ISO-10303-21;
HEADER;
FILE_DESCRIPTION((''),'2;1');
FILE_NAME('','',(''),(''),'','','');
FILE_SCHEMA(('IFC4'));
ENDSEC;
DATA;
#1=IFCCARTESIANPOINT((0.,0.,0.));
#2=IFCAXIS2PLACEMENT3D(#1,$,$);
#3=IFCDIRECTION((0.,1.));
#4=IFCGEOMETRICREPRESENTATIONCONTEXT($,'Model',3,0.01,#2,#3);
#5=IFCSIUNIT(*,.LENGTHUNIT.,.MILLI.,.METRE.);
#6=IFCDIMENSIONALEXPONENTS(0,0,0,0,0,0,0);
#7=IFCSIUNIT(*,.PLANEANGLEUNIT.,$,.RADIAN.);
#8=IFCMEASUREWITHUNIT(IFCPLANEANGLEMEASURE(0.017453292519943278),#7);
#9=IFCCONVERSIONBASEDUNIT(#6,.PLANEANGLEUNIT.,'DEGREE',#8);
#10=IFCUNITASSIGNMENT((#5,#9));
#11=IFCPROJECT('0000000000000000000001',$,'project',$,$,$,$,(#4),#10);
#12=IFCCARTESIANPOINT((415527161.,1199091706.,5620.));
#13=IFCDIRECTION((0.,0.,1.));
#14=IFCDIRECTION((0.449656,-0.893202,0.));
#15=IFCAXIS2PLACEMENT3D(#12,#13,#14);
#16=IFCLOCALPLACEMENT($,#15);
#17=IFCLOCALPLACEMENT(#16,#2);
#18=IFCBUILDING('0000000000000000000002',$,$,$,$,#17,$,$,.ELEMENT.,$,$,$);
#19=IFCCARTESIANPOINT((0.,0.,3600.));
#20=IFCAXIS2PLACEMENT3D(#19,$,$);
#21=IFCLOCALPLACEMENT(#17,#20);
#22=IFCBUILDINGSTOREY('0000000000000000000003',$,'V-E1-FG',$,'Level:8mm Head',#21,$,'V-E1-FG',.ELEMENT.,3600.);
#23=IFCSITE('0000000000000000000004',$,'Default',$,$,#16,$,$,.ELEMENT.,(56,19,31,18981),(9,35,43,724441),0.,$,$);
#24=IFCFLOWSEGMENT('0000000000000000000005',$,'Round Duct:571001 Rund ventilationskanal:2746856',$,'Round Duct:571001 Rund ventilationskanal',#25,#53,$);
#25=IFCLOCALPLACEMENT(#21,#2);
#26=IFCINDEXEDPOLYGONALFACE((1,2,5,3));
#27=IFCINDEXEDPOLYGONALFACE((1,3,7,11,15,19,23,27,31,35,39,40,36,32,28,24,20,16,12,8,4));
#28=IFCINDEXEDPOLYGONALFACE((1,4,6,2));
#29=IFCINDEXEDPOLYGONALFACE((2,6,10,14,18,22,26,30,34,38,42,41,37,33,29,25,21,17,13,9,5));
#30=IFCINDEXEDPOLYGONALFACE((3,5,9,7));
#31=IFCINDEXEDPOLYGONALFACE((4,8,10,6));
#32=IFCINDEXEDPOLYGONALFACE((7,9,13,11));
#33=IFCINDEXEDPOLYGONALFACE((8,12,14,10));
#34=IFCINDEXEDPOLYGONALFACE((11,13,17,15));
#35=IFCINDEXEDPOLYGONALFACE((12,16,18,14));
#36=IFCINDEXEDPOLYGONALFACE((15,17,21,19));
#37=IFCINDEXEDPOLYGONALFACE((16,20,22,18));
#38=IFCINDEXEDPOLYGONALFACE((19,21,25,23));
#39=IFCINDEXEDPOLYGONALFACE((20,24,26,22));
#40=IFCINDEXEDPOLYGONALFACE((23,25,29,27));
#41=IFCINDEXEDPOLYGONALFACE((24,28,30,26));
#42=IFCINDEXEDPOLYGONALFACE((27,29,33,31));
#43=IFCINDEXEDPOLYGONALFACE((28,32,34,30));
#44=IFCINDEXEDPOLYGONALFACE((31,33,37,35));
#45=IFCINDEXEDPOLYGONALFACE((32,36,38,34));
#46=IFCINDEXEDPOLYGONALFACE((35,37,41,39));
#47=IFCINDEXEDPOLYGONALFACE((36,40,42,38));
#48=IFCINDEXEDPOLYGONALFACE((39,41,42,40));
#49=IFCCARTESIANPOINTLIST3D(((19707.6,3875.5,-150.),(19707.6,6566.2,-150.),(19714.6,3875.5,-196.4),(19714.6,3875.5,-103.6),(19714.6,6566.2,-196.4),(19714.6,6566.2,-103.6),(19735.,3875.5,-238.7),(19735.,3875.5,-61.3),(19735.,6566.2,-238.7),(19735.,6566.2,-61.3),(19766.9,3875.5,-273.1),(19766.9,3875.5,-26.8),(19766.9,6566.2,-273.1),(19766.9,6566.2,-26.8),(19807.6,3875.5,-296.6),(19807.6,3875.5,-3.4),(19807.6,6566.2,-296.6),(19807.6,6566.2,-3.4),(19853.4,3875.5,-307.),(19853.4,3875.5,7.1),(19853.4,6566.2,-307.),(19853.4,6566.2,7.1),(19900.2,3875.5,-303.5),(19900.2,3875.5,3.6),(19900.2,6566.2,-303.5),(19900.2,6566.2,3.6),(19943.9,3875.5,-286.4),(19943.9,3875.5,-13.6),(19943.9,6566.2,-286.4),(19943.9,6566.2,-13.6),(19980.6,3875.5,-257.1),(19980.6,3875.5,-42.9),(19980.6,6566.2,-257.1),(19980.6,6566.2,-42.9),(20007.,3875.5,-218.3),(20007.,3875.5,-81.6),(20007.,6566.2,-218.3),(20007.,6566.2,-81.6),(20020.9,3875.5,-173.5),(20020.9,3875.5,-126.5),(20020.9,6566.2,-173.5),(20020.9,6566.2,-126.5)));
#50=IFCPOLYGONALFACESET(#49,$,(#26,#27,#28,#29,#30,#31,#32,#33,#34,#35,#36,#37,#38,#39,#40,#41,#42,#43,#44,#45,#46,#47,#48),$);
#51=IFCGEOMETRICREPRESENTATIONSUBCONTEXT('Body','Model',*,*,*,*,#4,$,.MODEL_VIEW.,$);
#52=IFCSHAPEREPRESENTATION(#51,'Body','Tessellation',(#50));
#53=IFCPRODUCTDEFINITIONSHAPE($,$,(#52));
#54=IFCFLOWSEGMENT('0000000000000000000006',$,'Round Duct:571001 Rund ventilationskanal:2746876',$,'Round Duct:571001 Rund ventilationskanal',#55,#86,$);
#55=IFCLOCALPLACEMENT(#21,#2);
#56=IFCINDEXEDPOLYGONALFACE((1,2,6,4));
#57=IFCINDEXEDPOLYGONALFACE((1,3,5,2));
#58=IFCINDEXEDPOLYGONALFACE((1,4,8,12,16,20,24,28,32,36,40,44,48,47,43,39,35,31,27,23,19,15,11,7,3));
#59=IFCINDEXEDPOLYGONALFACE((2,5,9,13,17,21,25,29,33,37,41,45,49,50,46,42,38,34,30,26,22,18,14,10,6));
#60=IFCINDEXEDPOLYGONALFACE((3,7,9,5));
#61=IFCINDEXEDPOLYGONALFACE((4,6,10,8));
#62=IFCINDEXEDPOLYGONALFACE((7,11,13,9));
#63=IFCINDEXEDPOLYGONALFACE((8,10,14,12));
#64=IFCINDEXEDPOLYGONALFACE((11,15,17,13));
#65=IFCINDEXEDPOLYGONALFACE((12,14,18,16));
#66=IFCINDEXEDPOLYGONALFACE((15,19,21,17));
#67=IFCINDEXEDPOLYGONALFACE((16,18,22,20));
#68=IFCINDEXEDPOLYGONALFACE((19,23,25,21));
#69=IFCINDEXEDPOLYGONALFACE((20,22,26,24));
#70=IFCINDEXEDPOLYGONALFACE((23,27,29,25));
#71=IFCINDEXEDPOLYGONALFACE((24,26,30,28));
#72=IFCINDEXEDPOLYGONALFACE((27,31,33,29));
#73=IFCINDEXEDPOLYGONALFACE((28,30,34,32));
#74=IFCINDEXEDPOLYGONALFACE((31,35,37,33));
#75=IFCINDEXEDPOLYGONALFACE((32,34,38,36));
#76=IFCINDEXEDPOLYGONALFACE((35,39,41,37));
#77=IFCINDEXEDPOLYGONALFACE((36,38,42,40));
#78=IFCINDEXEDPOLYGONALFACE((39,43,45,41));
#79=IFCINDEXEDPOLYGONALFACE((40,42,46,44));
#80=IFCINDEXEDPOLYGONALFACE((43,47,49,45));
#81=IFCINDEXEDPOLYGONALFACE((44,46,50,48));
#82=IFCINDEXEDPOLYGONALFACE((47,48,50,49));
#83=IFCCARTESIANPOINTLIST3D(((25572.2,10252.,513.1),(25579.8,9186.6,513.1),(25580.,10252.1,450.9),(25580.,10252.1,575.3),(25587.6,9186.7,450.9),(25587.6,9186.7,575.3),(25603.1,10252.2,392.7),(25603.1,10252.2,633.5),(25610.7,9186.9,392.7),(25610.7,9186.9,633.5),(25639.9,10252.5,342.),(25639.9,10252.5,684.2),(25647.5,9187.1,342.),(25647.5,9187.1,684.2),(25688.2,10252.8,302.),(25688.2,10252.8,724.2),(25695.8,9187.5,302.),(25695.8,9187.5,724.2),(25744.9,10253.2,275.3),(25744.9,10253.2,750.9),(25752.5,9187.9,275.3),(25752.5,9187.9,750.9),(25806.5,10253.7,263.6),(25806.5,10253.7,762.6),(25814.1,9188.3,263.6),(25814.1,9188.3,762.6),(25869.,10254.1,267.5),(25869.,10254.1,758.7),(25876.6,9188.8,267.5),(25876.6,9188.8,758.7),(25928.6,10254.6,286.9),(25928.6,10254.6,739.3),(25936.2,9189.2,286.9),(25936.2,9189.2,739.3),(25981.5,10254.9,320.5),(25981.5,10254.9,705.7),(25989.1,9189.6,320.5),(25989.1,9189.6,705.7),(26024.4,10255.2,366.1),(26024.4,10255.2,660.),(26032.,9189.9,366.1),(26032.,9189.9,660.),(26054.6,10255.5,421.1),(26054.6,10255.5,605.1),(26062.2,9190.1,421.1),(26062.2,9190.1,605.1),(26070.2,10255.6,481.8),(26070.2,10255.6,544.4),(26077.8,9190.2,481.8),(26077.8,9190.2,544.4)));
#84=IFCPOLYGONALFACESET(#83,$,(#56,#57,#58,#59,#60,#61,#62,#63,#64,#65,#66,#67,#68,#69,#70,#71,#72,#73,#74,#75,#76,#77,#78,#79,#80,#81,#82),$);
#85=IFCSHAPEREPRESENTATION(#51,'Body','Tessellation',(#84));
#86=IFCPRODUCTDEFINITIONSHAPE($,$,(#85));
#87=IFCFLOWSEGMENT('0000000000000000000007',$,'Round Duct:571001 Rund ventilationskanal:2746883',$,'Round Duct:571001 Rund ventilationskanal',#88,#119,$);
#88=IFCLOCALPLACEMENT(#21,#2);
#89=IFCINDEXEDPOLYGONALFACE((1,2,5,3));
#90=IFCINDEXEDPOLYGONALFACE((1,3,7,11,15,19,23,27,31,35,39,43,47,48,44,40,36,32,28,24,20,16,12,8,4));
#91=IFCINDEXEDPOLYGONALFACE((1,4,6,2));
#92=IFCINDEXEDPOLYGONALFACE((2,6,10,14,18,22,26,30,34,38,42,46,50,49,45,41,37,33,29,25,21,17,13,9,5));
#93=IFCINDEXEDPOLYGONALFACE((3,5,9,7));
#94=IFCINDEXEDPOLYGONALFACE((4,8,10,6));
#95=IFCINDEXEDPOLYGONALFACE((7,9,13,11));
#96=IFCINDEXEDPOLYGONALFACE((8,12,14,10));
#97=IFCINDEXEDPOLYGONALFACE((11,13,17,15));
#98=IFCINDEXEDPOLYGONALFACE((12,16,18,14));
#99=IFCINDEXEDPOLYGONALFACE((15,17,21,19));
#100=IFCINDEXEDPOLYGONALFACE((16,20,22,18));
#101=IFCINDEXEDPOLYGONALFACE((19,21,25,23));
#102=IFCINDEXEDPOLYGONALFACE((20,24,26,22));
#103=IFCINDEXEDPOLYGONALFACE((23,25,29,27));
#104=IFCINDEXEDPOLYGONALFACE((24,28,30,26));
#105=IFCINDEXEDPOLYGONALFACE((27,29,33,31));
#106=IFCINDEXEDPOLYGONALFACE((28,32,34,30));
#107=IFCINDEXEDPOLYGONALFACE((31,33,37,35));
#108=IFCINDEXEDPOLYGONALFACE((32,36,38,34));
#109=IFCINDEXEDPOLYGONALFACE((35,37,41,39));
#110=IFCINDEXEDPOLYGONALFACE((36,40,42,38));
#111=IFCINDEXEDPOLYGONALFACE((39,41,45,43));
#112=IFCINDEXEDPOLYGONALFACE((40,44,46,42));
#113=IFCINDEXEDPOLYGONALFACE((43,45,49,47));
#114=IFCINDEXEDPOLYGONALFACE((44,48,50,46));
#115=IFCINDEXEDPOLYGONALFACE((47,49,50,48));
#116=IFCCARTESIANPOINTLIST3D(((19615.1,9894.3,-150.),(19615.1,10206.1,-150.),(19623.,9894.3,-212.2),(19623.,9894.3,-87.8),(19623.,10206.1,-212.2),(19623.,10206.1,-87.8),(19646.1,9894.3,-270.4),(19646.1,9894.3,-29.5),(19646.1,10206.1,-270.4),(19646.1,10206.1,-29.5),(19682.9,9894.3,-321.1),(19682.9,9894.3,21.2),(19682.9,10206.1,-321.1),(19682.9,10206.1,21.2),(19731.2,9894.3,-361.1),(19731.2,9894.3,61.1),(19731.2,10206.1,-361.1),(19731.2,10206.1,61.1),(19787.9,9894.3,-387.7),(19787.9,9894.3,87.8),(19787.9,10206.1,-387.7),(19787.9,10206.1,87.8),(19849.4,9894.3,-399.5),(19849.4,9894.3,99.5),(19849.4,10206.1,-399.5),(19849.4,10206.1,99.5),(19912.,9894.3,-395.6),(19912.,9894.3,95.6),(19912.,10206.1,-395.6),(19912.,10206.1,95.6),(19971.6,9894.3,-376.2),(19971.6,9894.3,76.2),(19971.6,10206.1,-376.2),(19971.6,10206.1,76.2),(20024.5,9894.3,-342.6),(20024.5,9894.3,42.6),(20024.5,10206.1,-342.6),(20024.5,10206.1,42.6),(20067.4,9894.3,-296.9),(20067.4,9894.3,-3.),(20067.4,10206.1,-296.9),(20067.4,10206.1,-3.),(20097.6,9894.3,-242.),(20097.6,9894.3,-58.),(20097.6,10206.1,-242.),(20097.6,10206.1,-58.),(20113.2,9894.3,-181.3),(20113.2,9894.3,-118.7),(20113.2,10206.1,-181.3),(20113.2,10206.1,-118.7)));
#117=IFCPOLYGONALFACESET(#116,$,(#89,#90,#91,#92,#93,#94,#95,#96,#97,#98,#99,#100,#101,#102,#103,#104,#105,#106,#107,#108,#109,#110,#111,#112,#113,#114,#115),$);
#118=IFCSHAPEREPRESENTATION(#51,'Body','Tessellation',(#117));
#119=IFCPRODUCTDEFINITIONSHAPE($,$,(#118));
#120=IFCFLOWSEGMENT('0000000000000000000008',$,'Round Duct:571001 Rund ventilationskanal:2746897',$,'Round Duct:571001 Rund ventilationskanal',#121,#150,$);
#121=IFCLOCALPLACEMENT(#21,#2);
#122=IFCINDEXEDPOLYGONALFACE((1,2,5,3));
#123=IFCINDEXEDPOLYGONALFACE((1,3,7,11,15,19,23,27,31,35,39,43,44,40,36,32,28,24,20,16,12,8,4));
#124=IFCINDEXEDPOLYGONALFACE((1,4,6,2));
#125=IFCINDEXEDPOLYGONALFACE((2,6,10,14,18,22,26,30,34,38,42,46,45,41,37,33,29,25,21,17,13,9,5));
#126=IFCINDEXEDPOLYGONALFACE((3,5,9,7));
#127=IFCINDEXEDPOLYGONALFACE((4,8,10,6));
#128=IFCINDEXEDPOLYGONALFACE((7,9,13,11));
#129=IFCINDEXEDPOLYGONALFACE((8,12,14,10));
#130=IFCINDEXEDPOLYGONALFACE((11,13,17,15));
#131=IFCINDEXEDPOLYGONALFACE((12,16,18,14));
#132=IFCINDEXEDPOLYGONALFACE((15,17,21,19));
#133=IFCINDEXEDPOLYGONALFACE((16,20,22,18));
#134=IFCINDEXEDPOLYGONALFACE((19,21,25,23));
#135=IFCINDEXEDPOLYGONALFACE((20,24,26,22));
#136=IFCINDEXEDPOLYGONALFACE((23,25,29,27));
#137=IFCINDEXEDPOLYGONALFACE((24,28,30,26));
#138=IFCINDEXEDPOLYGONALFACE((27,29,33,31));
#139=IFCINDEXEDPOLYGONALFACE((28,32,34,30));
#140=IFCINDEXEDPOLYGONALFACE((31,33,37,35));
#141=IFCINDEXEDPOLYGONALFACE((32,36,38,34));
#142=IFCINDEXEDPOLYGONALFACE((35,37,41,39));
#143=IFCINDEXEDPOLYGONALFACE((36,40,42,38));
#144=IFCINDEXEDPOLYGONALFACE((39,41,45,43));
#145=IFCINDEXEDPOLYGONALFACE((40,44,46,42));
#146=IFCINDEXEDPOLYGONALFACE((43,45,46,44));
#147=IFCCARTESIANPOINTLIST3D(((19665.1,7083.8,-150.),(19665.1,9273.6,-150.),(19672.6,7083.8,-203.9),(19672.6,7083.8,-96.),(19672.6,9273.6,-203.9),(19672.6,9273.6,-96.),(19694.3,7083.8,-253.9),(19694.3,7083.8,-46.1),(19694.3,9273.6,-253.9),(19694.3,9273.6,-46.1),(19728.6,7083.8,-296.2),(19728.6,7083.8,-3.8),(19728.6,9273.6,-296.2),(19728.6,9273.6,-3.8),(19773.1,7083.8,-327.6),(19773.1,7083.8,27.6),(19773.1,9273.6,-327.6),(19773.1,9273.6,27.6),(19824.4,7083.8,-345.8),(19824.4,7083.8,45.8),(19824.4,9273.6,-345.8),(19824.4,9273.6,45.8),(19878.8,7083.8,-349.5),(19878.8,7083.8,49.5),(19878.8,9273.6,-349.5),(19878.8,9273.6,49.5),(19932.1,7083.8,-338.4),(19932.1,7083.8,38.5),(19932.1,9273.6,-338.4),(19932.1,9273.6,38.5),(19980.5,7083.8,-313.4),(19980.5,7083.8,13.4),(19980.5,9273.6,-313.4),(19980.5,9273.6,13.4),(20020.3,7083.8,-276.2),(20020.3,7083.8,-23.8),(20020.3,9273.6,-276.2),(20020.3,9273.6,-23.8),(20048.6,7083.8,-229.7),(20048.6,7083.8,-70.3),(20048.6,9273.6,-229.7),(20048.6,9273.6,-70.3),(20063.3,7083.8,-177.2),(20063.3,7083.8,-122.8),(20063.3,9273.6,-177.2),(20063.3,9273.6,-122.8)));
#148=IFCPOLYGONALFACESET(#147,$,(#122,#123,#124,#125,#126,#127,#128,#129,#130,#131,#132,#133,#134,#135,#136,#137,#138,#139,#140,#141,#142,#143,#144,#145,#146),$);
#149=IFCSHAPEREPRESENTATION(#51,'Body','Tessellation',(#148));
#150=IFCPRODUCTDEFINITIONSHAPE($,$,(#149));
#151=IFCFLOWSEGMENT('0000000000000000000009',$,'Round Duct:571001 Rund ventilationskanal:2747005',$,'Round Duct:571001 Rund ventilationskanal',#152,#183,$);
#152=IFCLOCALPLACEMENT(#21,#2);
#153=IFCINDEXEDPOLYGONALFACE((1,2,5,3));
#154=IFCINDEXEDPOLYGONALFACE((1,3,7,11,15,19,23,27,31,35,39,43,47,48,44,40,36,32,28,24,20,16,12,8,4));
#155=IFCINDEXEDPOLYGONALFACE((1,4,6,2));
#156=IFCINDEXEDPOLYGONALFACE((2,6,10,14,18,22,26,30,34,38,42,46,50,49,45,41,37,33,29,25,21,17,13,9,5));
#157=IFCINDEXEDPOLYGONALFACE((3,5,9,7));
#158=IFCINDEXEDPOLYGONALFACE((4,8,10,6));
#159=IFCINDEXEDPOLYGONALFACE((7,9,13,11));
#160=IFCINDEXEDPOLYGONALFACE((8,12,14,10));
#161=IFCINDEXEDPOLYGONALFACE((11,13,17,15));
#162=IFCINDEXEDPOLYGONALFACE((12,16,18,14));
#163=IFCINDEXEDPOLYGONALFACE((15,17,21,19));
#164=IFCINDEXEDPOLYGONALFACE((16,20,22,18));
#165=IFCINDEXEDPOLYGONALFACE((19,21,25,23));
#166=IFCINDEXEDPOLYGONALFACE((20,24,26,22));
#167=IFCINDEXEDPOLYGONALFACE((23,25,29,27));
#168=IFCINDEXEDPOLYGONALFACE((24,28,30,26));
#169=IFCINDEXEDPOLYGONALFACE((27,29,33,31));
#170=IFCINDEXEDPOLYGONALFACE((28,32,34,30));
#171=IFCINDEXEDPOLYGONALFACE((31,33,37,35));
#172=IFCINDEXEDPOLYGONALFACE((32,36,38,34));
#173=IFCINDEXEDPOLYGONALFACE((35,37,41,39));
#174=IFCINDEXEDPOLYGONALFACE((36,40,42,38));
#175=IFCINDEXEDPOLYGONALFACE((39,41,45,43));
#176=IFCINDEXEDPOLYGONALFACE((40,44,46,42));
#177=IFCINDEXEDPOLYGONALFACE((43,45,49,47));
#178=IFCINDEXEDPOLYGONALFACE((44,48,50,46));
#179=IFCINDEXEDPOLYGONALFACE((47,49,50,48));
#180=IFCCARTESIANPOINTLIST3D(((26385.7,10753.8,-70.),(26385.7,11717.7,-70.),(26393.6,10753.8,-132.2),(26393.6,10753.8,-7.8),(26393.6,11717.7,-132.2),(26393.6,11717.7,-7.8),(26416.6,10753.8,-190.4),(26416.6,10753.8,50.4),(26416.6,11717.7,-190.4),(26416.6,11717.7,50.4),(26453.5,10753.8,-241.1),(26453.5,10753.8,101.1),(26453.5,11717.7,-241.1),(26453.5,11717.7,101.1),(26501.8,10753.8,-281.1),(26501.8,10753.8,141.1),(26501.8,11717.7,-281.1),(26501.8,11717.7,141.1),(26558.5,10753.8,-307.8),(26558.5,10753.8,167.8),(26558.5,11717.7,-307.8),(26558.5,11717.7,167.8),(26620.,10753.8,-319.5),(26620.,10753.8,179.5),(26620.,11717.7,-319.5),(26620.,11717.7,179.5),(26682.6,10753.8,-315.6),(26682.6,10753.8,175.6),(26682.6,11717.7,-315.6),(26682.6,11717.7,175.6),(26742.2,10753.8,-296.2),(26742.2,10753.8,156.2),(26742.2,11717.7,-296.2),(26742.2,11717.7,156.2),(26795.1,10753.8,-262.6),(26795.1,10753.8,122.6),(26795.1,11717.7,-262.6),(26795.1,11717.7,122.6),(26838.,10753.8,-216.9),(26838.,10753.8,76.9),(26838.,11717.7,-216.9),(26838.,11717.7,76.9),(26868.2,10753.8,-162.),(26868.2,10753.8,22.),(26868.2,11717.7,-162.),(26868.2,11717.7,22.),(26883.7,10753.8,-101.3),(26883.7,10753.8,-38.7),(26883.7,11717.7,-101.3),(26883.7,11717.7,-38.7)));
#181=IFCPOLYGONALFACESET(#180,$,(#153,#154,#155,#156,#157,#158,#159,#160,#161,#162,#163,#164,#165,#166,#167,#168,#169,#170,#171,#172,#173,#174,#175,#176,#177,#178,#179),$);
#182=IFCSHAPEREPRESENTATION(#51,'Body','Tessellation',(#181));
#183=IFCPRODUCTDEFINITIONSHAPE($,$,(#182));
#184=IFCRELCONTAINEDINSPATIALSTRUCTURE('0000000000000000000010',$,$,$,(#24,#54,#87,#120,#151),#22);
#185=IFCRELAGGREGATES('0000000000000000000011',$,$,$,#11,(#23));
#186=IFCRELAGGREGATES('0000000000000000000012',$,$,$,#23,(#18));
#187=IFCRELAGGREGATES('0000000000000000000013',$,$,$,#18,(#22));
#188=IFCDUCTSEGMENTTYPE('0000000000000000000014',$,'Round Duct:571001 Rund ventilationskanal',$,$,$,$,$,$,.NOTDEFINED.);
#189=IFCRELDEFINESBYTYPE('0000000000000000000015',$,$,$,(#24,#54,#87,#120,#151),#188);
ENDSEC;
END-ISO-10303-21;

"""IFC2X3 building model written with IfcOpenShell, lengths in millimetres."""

from ifc_helpers import new_model, entity, si_unit, converted_unit, direction, frame, frame_2d, origin, origin_2d_with_axis, place, context, subcontext, project, spatial, circle, extrude, type_object, element, save


model = new_model("IFC2X3")

# Units and contexts
model_context = context("Model", 3, precision=0.01, world=origin(), true_north=direction((0.0, 1.0)))
body_context = subcontext(model_context, "Body", "Model", "MODEL_VIEW")
ifc_project = project(units=[si_unit("LENGTHUNIT", "METRE", prefix="MILLI"), converted_unit("PLANEANGLEUNIT", "DEGREE", entity("IfcPlaneAngleMeasure", 0.017453292519943278), si_unit("PLANEANGLEUNIT", "RADIAN"), dimensions=[0, 0, 0, 0, 0, 0, 0])], contexts=[model_context])

# Site, building, storey
site_placement = place(None, frame((415527161.0, 1199091706.0, 5620.0), z_axis=(0.0, 0.0, 1.0), x_axis=(0.449656, -0.893202, 0.0)))
site = spatial("IfcSite", under=ifc_project, at=site_placement, Name="Default", CompositionType="ELEMENT", RefLatitude=(56, 19, 31, 18981), RefLongitude=(9, 35, 43, 724441), RefElevation=0.0)
building_placement = place(site_placement, origin())
building = spatial("IfcBuilding", under=site, at=building_placement, CompositionType="ELEMENT")
storey_placement = place(building_placement, frame((0.0, 0.0, 3600.0)))
storey = spatial("IfcBuildingStorey", under=building, at=storey_placement, Name="V-E1-FG", ObjectType="Level:8mm Head", LongName="V-E1-FG", CompositionType="ELEMENT", Elevation=3600.0)

# Flow segments
duct_segment_type = type_object("IfcDuctSegmentType", Name="Round Duct:571001 Rund ventilationskanal", PredefinedType="NOTDEFINED")
flow_segment_1_placement = place(storey_placement, origin())
element("IfcFlowSegment", 1, at=flow_segment_1_placement, inside=storey, type_object=duct_segment_type, Name="Round Duct:571001 Rund ventilationskanal:2746856", ObjectType="Round Duct:571001 Rund ventilationskanal", context=body_context, shape_type="SweptSolid", body=[
    extrude(circle(Radius=157.5, at=origin_2d_with_axis()), frame((19865.1, 3875.5, -150.0), z_axis=(0.0, 1.0, 0.0), x_axis=(-1.0, 0.0, 0.0)), (0.0, 0.0, 1.0), 2690.7),
])
flow_segment_2_placement = place(storey_placement, origin())
element("IfcFlowSegment", 2, at=flow_segment_2_placement, inside=storey, type_object=duct_segment_type, Name="Round Duct:571001 Rund ventilationskanal:2746876", ObjectType="Round Duct:571001 Rund ventilationskanal", context=body_context, shape_type="SweptSolid", body=[
    extrude(circle(Radius=250.0, at=origin_2d_with_axis()), frame((25822.2, 10253.8, 513.1), z_axis=(0.007142, -0.999974, 0.0), x_axis=(-0.999974, -0.007142, 0.0)), (0.0, 0.0, 1.0), 1065.4),
])
flow_segment_3_placement = place(storey_placement, origin())
element("IfcFlowSegment", 3, at=flow_segment_3_placement, inside=storey, type_object=duct_segment_type, Name="Round Duct:571001 Rund ventilationskanal:2746883", ObjectType="Round Duct:571001 Rund ventilationskanal", context=body_context, shape_type="SweptSolid", body=[
    extrude(circle(Radius=250.0, at=frame_2d((0.0, 0.0), x_axis=(1.0, 0.0))), frame((19865.1, 9894.3, -150.0), z_axis=(0.0, 1.0, 0.0), x_axis=(-1.0, 0.0, 0.0)), (0.0, 0.0, 1.0), 311.8),
])
flow_segment_4_placement = place(storey_placement, origin())
element("IfcFlowSegment", 4, at=flow_segment_4_placement, inside=storey, type_object=duct_segment_type, Name="Round Duct:571001 Rund ventilationskanal:2746897", ObjectType="Round Duct:571001 Rund ventilationskanal", context=body_context, shape_type="SweptSolid", body=[
    extrude(circle(Radius=200.0, at=origin_2d_with_axis()), frame((19865.1, 7083.8, -150.0), z_axis=(0.0, 1.0, 0.0), x_axis=(-1.0, 0.0, 0.0)), (0.0, 0.0, 1.0), 2189.8),
])
flow_segment_5_placement = place(storey_placement, origin())
element("IfcFlowSegment", 5, at=flow_segment_5_placement, inside=storey, type_object=duct_segment_type, Name="Round Duct:571001 Rund ventilationskanal:2747005", ObjectType="Round Duct:571001 Rund ventilationskanal", context=body_context, shape_type="SweptSolid", body=[
    extrude(circle(Radius=250.0, at=frame_2d((0.0, 0.0), x_axis=(1.0, 0.0))), frame((26635.7, 10753.8, -70.0), z_axis=(0.0, 1.0, 0.0), x_axis=(-1.0, 0.0, 0.0)), (0.0, 0.0, 1.0), 963.9),
])

save(model, "model.ifc")
